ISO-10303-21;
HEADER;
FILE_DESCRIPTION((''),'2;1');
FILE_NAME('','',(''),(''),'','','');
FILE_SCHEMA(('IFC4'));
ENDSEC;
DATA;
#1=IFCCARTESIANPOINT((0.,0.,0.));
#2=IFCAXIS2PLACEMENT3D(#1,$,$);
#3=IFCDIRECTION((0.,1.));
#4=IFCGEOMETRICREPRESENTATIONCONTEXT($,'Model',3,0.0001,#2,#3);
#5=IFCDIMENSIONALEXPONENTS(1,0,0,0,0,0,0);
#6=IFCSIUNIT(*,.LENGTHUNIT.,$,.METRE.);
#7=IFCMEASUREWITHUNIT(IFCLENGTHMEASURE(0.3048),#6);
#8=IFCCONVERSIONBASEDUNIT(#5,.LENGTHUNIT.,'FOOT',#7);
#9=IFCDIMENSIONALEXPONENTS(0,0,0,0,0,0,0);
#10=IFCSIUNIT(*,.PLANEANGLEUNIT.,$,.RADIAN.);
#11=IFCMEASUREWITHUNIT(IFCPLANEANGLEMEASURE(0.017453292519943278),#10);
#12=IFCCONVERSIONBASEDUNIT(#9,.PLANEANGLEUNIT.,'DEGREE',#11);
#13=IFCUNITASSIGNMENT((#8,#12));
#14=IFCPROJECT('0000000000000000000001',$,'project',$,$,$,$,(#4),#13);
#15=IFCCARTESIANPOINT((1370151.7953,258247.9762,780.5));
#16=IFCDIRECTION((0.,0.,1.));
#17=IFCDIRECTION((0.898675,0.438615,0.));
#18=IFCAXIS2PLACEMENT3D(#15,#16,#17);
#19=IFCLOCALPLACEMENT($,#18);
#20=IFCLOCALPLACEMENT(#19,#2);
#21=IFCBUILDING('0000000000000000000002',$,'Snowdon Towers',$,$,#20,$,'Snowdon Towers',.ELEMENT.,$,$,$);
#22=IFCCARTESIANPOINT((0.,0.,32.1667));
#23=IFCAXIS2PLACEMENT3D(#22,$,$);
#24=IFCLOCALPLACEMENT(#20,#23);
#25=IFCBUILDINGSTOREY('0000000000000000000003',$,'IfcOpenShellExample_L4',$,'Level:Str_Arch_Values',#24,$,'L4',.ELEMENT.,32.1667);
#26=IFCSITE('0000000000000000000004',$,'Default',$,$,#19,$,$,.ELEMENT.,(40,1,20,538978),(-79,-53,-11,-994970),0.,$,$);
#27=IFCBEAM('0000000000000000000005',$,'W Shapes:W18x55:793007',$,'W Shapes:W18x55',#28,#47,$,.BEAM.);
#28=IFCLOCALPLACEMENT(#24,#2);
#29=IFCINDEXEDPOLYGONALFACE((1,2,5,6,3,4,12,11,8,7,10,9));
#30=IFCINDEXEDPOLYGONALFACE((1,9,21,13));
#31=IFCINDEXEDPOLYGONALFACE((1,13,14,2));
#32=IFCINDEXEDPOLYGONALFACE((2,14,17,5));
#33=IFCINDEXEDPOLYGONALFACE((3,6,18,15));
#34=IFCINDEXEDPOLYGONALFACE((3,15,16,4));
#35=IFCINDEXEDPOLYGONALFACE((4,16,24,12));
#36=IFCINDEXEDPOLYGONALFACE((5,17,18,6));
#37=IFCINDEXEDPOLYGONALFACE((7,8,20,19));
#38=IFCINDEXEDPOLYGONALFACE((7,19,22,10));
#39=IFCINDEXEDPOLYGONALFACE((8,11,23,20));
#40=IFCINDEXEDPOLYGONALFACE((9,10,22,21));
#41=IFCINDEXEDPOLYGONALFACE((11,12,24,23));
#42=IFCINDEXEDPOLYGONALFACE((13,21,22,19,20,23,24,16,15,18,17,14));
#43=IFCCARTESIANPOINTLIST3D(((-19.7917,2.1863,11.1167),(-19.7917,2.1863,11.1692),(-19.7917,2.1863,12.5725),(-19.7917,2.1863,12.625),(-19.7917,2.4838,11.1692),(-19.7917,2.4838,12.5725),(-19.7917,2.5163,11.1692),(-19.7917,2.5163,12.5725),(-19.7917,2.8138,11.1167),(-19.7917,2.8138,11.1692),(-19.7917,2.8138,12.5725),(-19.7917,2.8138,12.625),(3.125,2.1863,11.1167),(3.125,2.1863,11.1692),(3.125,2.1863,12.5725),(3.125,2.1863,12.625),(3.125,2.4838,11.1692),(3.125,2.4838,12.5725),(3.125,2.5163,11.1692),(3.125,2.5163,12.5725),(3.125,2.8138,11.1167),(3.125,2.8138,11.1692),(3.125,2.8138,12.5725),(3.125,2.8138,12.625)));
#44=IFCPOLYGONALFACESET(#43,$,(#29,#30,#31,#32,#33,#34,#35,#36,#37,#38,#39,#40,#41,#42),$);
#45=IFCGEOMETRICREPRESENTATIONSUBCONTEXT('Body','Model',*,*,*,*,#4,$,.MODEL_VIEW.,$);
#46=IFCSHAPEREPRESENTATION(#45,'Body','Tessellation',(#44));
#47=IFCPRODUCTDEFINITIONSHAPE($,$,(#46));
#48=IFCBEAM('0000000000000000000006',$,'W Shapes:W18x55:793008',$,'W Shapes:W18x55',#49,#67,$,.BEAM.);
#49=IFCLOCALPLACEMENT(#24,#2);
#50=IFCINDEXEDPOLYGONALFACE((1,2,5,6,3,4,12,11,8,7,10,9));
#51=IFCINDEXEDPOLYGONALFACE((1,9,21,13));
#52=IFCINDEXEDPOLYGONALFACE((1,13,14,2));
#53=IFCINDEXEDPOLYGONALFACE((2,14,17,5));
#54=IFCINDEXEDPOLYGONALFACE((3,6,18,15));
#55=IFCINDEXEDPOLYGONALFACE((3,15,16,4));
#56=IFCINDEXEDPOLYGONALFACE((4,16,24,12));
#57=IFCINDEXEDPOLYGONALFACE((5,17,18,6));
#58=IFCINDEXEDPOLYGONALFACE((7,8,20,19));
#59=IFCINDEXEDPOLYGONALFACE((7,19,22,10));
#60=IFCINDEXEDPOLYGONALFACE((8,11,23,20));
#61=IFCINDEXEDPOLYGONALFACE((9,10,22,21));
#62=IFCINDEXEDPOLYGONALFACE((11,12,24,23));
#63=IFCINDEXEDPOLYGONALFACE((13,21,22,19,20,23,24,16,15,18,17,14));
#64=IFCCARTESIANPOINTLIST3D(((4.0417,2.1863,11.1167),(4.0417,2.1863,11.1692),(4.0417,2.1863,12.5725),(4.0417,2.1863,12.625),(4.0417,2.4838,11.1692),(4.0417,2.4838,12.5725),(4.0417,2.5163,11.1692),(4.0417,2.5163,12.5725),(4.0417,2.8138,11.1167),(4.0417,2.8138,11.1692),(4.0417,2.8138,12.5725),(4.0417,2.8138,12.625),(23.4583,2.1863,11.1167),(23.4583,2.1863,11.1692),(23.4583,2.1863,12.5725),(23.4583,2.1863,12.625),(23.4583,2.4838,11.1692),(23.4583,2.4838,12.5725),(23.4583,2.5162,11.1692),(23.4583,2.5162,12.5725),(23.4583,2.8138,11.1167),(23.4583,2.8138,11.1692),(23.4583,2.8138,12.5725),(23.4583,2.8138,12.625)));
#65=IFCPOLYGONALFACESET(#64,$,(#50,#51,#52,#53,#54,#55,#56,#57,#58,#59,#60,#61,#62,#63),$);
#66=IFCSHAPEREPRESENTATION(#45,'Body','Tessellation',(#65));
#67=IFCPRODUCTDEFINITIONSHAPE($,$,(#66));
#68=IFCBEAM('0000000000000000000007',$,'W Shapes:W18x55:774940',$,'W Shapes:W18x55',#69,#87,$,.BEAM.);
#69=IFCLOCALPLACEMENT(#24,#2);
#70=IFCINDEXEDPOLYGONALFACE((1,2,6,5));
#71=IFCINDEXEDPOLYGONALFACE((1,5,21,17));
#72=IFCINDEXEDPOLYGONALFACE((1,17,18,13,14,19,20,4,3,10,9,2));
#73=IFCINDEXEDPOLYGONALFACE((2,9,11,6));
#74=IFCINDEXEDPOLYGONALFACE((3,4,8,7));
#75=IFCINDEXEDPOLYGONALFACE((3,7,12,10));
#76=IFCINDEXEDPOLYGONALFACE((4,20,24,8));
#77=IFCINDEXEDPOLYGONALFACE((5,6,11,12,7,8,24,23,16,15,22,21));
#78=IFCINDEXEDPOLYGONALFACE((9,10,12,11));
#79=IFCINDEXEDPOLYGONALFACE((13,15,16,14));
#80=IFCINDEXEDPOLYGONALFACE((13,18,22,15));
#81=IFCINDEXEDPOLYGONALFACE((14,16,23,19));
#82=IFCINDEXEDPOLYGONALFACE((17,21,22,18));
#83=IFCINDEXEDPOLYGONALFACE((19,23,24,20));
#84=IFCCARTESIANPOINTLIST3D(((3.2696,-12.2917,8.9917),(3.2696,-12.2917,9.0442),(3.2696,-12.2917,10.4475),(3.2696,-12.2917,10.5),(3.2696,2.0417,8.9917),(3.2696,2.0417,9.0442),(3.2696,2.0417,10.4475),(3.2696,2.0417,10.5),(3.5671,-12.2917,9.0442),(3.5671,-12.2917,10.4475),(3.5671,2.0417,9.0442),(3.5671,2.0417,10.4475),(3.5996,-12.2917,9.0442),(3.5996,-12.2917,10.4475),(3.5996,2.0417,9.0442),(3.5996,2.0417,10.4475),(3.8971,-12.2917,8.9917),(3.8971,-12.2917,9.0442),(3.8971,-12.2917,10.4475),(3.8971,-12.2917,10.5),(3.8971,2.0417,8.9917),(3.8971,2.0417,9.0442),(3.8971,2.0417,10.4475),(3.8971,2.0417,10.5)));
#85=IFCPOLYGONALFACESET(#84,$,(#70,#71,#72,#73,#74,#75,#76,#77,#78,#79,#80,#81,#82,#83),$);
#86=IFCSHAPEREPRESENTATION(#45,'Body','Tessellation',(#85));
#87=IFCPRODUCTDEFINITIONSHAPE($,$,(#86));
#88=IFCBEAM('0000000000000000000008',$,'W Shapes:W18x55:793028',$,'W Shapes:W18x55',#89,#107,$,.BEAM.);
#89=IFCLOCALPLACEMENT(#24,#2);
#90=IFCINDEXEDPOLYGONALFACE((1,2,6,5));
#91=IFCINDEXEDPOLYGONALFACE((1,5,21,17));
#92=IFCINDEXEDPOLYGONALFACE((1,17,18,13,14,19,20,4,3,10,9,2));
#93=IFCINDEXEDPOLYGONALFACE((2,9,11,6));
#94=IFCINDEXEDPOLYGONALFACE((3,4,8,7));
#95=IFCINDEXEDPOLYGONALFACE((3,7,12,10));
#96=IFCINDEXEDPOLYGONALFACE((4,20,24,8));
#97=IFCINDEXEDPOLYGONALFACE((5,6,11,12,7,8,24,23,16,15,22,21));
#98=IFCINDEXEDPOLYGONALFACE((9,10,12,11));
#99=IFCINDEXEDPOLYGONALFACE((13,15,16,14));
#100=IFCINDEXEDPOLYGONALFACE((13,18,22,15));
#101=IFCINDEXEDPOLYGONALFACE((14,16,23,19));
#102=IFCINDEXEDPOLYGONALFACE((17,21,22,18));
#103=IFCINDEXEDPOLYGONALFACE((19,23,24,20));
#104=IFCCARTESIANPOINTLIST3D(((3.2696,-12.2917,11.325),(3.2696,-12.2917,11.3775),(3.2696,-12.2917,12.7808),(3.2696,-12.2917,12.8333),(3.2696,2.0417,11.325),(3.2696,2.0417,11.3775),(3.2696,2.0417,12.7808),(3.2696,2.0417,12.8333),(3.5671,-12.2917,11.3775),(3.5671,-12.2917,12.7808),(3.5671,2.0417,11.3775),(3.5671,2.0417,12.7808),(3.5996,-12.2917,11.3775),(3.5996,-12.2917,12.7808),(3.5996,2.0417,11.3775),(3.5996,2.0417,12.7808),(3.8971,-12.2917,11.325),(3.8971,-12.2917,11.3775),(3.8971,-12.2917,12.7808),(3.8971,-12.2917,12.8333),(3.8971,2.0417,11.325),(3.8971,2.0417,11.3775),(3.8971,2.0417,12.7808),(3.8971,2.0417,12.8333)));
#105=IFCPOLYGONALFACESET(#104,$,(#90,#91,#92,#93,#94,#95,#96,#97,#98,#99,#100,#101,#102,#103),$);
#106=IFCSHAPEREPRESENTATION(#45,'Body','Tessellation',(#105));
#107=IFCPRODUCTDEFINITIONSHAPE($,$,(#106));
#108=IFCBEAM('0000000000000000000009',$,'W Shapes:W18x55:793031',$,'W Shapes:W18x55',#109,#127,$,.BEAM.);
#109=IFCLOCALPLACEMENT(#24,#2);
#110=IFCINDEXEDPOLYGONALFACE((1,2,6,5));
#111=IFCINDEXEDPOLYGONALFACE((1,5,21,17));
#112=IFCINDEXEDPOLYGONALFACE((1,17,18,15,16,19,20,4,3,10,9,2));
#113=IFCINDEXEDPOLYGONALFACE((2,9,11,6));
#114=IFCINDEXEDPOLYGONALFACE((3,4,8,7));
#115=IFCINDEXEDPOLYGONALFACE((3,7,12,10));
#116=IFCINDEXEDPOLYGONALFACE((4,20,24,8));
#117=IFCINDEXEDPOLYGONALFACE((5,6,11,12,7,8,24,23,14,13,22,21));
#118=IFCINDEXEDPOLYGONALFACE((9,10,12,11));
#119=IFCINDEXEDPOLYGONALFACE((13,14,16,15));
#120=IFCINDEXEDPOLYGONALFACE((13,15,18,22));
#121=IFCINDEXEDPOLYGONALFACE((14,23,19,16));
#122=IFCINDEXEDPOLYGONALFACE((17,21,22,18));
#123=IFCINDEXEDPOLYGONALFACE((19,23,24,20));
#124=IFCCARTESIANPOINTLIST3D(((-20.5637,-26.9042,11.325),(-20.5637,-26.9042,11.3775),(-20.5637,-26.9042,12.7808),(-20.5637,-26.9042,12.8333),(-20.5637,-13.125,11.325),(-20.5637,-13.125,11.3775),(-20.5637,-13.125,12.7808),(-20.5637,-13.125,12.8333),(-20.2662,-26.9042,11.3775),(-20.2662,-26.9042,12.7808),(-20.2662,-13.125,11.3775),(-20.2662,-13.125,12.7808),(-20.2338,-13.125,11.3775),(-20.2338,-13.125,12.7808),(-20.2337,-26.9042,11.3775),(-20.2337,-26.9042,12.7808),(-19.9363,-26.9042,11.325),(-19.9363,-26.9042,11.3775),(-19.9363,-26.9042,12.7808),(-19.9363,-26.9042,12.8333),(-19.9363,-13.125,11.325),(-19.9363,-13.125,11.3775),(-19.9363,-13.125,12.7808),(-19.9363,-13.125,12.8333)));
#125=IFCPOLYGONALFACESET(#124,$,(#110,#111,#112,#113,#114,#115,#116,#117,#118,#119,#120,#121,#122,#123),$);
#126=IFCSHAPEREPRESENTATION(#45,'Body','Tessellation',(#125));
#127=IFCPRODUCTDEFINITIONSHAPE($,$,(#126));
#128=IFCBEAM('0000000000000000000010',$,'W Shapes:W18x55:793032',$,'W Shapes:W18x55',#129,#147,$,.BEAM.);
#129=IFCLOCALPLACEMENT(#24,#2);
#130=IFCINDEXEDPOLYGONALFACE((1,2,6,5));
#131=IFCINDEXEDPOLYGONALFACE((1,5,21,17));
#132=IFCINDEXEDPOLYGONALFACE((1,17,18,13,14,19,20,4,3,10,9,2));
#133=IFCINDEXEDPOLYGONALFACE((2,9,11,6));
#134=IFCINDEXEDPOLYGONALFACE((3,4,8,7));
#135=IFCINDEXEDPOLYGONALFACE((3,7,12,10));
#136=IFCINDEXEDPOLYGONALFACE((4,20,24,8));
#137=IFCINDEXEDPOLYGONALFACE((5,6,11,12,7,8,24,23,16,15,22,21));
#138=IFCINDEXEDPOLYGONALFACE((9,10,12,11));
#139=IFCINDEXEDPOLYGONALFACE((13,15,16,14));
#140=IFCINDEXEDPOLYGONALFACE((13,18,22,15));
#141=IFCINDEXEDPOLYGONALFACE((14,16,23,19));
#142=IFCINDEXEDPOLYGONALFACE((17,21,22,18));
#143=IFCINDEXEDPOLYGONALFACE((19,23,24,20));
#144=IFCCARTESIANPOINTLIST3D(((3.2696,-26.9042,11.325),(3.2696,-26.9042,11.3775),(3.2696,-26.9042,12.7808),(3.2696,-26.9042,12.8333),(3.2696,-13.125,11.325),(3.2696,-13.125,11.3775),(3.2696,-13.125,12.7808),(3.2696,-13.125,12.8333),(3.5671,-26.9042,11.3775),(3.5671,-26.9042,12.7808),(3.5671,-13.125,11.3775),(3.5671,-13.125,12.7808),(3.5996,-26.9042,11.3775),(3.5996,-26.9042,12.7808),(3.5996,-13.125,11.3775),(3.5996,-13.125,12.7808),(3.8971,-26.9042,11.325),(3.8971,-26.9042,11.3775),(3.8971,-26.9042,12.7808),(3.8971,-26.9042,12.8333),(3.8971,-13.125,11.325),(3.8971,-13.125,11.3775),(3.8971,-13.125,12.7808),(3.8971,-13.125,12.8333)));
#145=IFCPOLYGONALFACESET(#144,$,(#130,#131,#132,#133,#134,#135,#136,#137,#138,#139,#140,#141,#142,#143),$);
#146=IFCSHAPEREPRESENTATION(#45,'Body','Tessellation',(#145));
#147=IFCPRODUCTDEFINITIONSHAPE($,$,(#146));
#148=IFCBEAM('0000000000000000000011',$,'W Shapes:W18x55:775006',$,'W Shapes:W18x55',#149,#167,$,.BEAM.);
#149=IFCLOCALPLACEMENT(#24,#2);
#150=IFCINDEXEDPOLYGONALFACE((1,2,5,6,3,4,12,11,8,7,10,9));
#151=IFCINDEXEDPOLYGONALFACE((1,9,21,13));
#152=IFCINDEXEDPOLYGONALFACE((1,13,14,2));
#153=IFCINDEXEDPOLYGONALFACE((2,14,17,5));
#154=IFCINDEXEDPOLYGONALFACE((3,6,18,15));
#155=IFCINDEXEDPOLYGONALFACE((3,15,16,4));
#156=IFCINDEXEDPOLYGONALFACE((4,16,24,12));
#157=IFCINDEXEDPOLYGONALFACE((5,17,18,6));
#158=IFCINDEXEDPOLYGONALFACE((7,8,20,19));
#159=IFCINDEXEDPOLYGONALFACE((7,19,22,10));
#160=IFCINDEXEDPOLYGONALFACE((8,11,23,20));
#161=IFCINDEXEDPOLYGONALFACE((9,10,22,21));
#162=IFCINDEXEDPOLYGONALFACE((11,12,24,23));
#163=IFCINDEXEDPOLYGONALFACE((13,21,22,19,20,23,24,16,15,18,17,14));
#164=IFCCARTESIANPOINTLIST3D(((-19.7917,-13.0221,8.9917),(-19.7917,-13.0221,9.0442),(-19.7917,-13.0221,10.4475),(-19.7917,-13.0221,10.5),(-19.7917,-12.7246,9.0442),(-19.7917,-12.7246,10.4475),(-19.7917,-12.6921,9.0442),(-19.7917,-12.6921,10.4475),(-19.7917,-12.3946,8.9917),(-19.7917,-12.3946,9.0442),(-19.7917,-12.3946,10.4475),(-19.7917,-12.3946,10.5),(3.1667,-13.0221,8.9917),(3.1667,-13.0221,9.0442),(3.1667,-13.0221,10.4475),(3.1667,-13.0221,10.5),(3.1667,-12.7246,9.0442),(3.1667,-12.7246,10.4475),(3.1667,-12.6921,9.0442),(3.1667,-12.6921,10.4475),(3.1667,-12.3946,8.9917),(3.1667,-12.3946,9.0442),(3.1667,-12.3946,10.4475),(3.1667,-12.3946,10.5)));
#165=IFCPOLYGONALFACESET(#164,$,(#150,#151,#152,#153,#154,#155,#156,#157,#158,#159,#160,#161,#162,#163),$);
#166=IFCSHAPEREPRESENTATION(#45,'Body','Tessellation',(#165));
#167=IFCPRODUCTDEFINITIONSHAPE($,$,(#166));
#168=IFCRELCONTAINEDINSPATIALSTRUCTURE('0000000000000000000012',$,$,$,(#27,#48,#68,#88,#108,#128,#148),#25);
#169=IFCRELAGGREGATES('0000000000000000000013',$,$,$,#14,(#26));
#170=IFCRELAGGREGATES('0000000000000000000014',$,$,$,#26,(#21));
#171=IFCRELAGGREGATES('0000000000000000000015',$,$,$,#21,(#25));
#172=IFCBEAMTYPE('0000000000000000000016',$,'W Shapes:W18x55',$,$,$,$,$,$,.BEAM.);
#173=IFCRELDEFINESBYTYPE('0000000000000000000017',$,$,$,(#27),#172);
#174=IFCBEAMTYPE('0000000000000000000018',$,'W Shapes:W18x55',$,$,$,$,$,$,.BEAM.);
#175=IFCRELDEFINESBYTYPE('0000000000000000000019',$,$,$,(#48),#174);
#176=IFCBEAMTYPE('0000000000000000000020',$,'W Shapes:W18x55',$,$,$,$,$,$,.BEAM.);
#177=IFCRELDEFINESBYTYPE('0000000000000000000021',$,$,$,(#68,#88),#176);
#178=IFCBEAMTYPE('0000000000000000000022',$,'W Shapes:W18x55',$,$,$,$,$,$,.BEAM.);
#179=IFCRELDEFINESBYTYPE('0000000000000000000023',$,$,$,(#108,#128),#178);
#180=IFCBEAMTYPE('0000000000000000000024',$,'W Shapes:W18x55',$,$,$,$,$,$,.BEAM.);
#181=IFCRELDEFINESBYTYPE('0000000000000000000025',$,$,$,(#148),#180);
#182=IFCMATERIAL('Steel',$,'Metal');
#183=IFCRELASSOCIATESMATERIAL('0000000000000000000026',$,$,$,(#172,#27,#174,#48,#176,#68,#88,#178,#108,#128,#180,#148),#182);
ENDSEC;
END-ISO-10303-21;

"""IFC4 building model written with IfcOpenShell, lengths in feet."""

from ifc_helpers import new_model, entity, si_unit, converted_unit, direction, frame, origin, place, context, subcontext, project, spatial, indexed_curve, outline, extrude, source, transform, mapped, material, type_object, type_shapes, element, save


model = new_model("IFC4")

# Units and contexts
model_context = context("Model", 3, precision=0.0001, world=origin(), true_north=direction((0.0, 1.0)))
body_context = subcontext(model_context, "Body", "Model", "MODEL_VIEW")
ifc_project = project(units=[converted_unit("LENGTHUNIT", "FOOT", entity("IfcLengthMeasure", 0.3048), si_unit("LENGTHUNIT", "METRE"), dimensions=[1, 0, 0, 0, 0, 0, 0]), converted_unit("PLANEANGLEUNIT", "DEGREE", entity("IfcPlaneAngleMeasure", 0.017453292519943278), si_unit("PLANEANGLEUNIT", "RADIAN"), dimensions=[0, 0, 0, 0, 0, 0, 0])], contexts=[model_context])

# Site, building, storey
site_placement = place(None, frame((1370151.7953, 258247.9762, 780.5), z_axis=(0.0, 0.0, 1.0), x_axis=(0.898675, 0.438615, 0.0)))
site = spatial("IfcSite", under=ifc_project, at=site_placement, Name="Default", CompositionType="ELEMENT", RefLatitude=(40, 1, 20, 538978), RefLongitude=(-79, -53, -11, -994970), RefElevation=0.0)
building_placement = place(site_placement, origin())
building = spatial("IfcBuilding", under=site, at=building_placement, Name="Snowdon Towers", LongName="Snowdon Towers", CompositionType="ELEMENT")
storey_placement = place(building_placement, frame((0.0, 0.0, 32.1667)))
storey = spatial("IfcBuildingStorey", under=building, at=storey_placement, Name="IfcOpenShellExample_L4", ObjectType="Level:Str_Arch_Values", LongName="L4", CompositionType="ELEMENT", Elevation=32.1667)

# Beams
ifc_material_1 = material(Name="Steel", Category="Metal")
beam_type_1 = type_object("IfcBeamType", Name="W Shapes:W18x55", PredefinedType="BEAM", material=ifc_material_1)
shared_shape_1 = source(origin(), body_context, "Body", "SweptSolid", [
    extrude(outline(indexed_curve([(-0.3138, -0.7017), (-0.3138, -0.7542), (0.3138, -0.7542), (0.3138, -0.7017), (0.0162, -0.7017), (0.0162, 0.7017), (0.3138, 0.7017), (0.3138, 0.7542), (-0.3137, 0.7542), (-0.3137, 0.7017), (-0.0163, 0.7017), (-0.0163, -0.7017), (-0.3138, -0.7017)], self_intersect=False)), frame((-11.5417, 0.0, 0.0), z_axis=(-1.0, 0.0, 0.0), x_axis=(0.0, -1.0, 0.0)), (0.0, 0.0, -1.0), 22.9167),
])
type_shapes(beam_type_1, [shared_shape_1])
beam_1_placement = place(storey_placement, frame((-8.25, 2.5, 11.8708)))
element("IfcBeam", 1, at=beam_1_placement, inside=storey, type_object=beam_type_1, material=ifc_material_1, Name="W Shapes:W18x55:793007", ObjectType="W Shapes:W18x55", PredefinedType="BEAM", context=body_context, shape_type="MappedRepresentation", body=[
    mapped(shared_shape_1, transform((0.0, 0.0, 0.0), scale=1.0)),
])
beam_type_2 = type_object("IfcBeamType", Name="W Shapes:W18x55", PredefinedType="BEAM", material=ifc_material_1)
shared_shape_2 = source(origin(), body_context, "Body", "SweptSolid", [
    extrude(outline(indexed_curve([(-0.3138, -0.7017), (-0.3138, -0.7542), (0.3138, -0.7542), (0.3138, -0.7017), (0.0162, -0.7017), (0.0162, 0.7017), (0.3138, 0.7017), (0.3138, 0.7542), (-0.3137, 0.7542), (-0.3137, 0.7017), (-0.0163, 0.7017), (-0.0163, -0.7017), (-0.3138, -0.7017)], self_intersect=False)), frame((-9.7917, 0.0, 0.0), z_axis=(-1.0, 0.0, 0.0), x_axis=(0.0, -1.0, 0.0)), (0.0, 0.0, -1.0), 19.4167),
])
type_shapes(beam_type_2, [shared_shape_2])
beam_2_placement = place(storey_placement, frame((13.8333, 2.5, 11.8708)))
element("IfcBeam", 2, at=beam_2_placement, inside=storey, type_object=beam_type_2, material=ifc_material_1, Name="W Shapes:W18x55:793008", ObjectType="W Shapes:W18x55", PredefinedType="BEAM", context=body_context, shape_type="MappedRepresentation", body=[
    mapped(shared_shape_2, transform((0.0, 0.0, 0.0), scale=1.0)),
])
beam_type_3 = type_object("IfcBeamType", Name="W Shapes:W18x55", PredefinedType="BEAM", material=ifc_material_1)
shared_shape_3 = source(origin(), body_context, "Body", "SweptSolid", [
    extrude(outline(indexed_curve([(-0.3138, -0.7017), (-0.3138, -0.7542), (0.3138, -0.7542), (0.3138, -0.7017), (0.0162, -0.7017), (0.0162, 0.7017), (0.3138, 0.7017), (0.3138, 0.7542), (-0.3137, 0.7542), (-0.3137, 0.7017), (-0.0163, 0.7017), (-0.0163, -0.7017), (-0.3138, -0.7017)], self_intersect=False)), frame((-7.1458, 0.0, 0.0), z_axis=(-1.0, 0.0, 0.0), x_axis=(0.0, -1.0, 0.0)), (0.0, 0.0, -1.0), 14.3333),
])
type_shapes(beam_type_3, [shared_shape_3])
for number, where, z_axis, x_axis, name in (
    (3, (3.5833, -5.1042, 9.7458), (0.0, 0.0, 1.0), (0.0, -1.0, 0.0), "W Shapes:W18x55:774940"),
    (4, (3.5833, -5.1042, 12.0792), (0.0, 0.0, 1.0), (0.0, -1.0, 0.0), "W Shapes:W18x55:793028"),
):
    element("IfcBeam", number, at=place(storey_placement, frame(where, z_axis=z_axis, x_axis=x_axis)), inside=storey, type_object=beam_type_3, material=ifc_material_1, Name=name, ObjectType="W Shapes:W18x55", PredefinedType="BEAM", context=body_context, shape_type="MappedRepresentation", body=[
        mapped(shared_shape_3, transform((0.0, 0.0, 0.0), scale=1.0)),
    ])
beam_type_4 = type_object("IfcBeamType", Name="W Shapes:W18x55", PredefinedType="BEAM", material=ifc_material_1)
shared_shape_4 = source(origin(), body_context, "Body", "SweptSolid", [
    extrude(outline(indexed_curve([(-0.3138, -0.7017), (-0.3138, -0.7542), (0.3138, -0.7542), (0.3138, -0.7017), (0.0162, -0.7017), (0.0162, 0.7017), (0.3138, 0.7017), (0.3138, 0.7542), (-0.3137, 0.7542), (-0.3137, 0.7017), (-0.0163, 0.7017), (-0.0163, -0.7017), (-0.3138, -0.7017)], self_intersect=False)), frame((-7.2292, 0.0, 0.0), z_axis=(-1.0, 0.0, 0.0), x_axis=(0.0, -1.0, 0.0)), (0.0, 0.0, -1.0), 13.7792),
])
type_shapes(beam_type_4, [shared_shape_4])
for number, where, z_axis, x_axis, name in (
    (5, (-20.25, -20.3542, 12.0792), (0.0, 0.0, 1.0), (0.0, -1.0, 0.0), "W Shapes:W18x55:793031"),
    (6, (3.5833, -20.3542, 12.0792), (0.0, 0.0, 1.0), (0.0, -1.0, 0.0), "W Shapes:W18x55:793032"),
):
    element("IfcBeam", number, at=place(storey_placement, frame(where, z_axis=z_axis, x_axis=x_axis)), inside=storey, type_object=beam_type_4, material=ifc_material_1, Name=name, ObjectType="W Shapes:W18x55", PredefinedType="BEAM", context=body_context, shape_type="MappedRepresentation", body=[
        mapped(shared_shape_4, transform((0.0, 0.0, 0.0), scale=1.0)),
    ])

# Beam
beam_type_5 = type_object("IfcBeamType", Name="W Shapes:W18x55", PredefinedType="BEAM", material=ifc_material_1)
shared_shape_5 = source(origin(), body_context, "Body", "SweptSolid", [
    extrude(outline(indexed_curve([(-0.3138, -0.7017), (-0.3138, -0.7542), (0.3138, -0.7542), (0.3138, -0.7017), (0.0162, -0.7017), (0.0162, 0.7017), (0.3138, 0.7017), (0.3138, 0.7542), (-0.3137, 0.7542), (-0.3137, 0.7017), (-0.0163, 0.7017), (-0.0163, -0.7017), (-0.3138, -0.7017)], self_intersect=False)), frame((-11.4583, 0.0, 0.0), z_axis=(-1.0, 0.0, 0.0), x_axis=(0.0, -1.0, 0.0)), (0.0, 0.0, -1.0), 22.9583),
])
type_shapes(beam_type_5, [shared_shape_5])
beam_3_placement = place(storey_placement, frame((-8.3333, -12.7083, 9.7458)))
element("IfcBeam", 7, at=beam_3_placement, inside=storey, type_object=beam_type_5, material=ifc_material_1, Name="W Shapes:W18x55:775006", ObjectType="W Shapes:W18x55", PredefinedType="BEAM", context=body_context, shape_type="MappedRepresentation", body=[
    mapped(shared_shape_5, transform((0.0, 0.0, 0.0), scale=1.0)),
])

save(model, "model.ifc")
